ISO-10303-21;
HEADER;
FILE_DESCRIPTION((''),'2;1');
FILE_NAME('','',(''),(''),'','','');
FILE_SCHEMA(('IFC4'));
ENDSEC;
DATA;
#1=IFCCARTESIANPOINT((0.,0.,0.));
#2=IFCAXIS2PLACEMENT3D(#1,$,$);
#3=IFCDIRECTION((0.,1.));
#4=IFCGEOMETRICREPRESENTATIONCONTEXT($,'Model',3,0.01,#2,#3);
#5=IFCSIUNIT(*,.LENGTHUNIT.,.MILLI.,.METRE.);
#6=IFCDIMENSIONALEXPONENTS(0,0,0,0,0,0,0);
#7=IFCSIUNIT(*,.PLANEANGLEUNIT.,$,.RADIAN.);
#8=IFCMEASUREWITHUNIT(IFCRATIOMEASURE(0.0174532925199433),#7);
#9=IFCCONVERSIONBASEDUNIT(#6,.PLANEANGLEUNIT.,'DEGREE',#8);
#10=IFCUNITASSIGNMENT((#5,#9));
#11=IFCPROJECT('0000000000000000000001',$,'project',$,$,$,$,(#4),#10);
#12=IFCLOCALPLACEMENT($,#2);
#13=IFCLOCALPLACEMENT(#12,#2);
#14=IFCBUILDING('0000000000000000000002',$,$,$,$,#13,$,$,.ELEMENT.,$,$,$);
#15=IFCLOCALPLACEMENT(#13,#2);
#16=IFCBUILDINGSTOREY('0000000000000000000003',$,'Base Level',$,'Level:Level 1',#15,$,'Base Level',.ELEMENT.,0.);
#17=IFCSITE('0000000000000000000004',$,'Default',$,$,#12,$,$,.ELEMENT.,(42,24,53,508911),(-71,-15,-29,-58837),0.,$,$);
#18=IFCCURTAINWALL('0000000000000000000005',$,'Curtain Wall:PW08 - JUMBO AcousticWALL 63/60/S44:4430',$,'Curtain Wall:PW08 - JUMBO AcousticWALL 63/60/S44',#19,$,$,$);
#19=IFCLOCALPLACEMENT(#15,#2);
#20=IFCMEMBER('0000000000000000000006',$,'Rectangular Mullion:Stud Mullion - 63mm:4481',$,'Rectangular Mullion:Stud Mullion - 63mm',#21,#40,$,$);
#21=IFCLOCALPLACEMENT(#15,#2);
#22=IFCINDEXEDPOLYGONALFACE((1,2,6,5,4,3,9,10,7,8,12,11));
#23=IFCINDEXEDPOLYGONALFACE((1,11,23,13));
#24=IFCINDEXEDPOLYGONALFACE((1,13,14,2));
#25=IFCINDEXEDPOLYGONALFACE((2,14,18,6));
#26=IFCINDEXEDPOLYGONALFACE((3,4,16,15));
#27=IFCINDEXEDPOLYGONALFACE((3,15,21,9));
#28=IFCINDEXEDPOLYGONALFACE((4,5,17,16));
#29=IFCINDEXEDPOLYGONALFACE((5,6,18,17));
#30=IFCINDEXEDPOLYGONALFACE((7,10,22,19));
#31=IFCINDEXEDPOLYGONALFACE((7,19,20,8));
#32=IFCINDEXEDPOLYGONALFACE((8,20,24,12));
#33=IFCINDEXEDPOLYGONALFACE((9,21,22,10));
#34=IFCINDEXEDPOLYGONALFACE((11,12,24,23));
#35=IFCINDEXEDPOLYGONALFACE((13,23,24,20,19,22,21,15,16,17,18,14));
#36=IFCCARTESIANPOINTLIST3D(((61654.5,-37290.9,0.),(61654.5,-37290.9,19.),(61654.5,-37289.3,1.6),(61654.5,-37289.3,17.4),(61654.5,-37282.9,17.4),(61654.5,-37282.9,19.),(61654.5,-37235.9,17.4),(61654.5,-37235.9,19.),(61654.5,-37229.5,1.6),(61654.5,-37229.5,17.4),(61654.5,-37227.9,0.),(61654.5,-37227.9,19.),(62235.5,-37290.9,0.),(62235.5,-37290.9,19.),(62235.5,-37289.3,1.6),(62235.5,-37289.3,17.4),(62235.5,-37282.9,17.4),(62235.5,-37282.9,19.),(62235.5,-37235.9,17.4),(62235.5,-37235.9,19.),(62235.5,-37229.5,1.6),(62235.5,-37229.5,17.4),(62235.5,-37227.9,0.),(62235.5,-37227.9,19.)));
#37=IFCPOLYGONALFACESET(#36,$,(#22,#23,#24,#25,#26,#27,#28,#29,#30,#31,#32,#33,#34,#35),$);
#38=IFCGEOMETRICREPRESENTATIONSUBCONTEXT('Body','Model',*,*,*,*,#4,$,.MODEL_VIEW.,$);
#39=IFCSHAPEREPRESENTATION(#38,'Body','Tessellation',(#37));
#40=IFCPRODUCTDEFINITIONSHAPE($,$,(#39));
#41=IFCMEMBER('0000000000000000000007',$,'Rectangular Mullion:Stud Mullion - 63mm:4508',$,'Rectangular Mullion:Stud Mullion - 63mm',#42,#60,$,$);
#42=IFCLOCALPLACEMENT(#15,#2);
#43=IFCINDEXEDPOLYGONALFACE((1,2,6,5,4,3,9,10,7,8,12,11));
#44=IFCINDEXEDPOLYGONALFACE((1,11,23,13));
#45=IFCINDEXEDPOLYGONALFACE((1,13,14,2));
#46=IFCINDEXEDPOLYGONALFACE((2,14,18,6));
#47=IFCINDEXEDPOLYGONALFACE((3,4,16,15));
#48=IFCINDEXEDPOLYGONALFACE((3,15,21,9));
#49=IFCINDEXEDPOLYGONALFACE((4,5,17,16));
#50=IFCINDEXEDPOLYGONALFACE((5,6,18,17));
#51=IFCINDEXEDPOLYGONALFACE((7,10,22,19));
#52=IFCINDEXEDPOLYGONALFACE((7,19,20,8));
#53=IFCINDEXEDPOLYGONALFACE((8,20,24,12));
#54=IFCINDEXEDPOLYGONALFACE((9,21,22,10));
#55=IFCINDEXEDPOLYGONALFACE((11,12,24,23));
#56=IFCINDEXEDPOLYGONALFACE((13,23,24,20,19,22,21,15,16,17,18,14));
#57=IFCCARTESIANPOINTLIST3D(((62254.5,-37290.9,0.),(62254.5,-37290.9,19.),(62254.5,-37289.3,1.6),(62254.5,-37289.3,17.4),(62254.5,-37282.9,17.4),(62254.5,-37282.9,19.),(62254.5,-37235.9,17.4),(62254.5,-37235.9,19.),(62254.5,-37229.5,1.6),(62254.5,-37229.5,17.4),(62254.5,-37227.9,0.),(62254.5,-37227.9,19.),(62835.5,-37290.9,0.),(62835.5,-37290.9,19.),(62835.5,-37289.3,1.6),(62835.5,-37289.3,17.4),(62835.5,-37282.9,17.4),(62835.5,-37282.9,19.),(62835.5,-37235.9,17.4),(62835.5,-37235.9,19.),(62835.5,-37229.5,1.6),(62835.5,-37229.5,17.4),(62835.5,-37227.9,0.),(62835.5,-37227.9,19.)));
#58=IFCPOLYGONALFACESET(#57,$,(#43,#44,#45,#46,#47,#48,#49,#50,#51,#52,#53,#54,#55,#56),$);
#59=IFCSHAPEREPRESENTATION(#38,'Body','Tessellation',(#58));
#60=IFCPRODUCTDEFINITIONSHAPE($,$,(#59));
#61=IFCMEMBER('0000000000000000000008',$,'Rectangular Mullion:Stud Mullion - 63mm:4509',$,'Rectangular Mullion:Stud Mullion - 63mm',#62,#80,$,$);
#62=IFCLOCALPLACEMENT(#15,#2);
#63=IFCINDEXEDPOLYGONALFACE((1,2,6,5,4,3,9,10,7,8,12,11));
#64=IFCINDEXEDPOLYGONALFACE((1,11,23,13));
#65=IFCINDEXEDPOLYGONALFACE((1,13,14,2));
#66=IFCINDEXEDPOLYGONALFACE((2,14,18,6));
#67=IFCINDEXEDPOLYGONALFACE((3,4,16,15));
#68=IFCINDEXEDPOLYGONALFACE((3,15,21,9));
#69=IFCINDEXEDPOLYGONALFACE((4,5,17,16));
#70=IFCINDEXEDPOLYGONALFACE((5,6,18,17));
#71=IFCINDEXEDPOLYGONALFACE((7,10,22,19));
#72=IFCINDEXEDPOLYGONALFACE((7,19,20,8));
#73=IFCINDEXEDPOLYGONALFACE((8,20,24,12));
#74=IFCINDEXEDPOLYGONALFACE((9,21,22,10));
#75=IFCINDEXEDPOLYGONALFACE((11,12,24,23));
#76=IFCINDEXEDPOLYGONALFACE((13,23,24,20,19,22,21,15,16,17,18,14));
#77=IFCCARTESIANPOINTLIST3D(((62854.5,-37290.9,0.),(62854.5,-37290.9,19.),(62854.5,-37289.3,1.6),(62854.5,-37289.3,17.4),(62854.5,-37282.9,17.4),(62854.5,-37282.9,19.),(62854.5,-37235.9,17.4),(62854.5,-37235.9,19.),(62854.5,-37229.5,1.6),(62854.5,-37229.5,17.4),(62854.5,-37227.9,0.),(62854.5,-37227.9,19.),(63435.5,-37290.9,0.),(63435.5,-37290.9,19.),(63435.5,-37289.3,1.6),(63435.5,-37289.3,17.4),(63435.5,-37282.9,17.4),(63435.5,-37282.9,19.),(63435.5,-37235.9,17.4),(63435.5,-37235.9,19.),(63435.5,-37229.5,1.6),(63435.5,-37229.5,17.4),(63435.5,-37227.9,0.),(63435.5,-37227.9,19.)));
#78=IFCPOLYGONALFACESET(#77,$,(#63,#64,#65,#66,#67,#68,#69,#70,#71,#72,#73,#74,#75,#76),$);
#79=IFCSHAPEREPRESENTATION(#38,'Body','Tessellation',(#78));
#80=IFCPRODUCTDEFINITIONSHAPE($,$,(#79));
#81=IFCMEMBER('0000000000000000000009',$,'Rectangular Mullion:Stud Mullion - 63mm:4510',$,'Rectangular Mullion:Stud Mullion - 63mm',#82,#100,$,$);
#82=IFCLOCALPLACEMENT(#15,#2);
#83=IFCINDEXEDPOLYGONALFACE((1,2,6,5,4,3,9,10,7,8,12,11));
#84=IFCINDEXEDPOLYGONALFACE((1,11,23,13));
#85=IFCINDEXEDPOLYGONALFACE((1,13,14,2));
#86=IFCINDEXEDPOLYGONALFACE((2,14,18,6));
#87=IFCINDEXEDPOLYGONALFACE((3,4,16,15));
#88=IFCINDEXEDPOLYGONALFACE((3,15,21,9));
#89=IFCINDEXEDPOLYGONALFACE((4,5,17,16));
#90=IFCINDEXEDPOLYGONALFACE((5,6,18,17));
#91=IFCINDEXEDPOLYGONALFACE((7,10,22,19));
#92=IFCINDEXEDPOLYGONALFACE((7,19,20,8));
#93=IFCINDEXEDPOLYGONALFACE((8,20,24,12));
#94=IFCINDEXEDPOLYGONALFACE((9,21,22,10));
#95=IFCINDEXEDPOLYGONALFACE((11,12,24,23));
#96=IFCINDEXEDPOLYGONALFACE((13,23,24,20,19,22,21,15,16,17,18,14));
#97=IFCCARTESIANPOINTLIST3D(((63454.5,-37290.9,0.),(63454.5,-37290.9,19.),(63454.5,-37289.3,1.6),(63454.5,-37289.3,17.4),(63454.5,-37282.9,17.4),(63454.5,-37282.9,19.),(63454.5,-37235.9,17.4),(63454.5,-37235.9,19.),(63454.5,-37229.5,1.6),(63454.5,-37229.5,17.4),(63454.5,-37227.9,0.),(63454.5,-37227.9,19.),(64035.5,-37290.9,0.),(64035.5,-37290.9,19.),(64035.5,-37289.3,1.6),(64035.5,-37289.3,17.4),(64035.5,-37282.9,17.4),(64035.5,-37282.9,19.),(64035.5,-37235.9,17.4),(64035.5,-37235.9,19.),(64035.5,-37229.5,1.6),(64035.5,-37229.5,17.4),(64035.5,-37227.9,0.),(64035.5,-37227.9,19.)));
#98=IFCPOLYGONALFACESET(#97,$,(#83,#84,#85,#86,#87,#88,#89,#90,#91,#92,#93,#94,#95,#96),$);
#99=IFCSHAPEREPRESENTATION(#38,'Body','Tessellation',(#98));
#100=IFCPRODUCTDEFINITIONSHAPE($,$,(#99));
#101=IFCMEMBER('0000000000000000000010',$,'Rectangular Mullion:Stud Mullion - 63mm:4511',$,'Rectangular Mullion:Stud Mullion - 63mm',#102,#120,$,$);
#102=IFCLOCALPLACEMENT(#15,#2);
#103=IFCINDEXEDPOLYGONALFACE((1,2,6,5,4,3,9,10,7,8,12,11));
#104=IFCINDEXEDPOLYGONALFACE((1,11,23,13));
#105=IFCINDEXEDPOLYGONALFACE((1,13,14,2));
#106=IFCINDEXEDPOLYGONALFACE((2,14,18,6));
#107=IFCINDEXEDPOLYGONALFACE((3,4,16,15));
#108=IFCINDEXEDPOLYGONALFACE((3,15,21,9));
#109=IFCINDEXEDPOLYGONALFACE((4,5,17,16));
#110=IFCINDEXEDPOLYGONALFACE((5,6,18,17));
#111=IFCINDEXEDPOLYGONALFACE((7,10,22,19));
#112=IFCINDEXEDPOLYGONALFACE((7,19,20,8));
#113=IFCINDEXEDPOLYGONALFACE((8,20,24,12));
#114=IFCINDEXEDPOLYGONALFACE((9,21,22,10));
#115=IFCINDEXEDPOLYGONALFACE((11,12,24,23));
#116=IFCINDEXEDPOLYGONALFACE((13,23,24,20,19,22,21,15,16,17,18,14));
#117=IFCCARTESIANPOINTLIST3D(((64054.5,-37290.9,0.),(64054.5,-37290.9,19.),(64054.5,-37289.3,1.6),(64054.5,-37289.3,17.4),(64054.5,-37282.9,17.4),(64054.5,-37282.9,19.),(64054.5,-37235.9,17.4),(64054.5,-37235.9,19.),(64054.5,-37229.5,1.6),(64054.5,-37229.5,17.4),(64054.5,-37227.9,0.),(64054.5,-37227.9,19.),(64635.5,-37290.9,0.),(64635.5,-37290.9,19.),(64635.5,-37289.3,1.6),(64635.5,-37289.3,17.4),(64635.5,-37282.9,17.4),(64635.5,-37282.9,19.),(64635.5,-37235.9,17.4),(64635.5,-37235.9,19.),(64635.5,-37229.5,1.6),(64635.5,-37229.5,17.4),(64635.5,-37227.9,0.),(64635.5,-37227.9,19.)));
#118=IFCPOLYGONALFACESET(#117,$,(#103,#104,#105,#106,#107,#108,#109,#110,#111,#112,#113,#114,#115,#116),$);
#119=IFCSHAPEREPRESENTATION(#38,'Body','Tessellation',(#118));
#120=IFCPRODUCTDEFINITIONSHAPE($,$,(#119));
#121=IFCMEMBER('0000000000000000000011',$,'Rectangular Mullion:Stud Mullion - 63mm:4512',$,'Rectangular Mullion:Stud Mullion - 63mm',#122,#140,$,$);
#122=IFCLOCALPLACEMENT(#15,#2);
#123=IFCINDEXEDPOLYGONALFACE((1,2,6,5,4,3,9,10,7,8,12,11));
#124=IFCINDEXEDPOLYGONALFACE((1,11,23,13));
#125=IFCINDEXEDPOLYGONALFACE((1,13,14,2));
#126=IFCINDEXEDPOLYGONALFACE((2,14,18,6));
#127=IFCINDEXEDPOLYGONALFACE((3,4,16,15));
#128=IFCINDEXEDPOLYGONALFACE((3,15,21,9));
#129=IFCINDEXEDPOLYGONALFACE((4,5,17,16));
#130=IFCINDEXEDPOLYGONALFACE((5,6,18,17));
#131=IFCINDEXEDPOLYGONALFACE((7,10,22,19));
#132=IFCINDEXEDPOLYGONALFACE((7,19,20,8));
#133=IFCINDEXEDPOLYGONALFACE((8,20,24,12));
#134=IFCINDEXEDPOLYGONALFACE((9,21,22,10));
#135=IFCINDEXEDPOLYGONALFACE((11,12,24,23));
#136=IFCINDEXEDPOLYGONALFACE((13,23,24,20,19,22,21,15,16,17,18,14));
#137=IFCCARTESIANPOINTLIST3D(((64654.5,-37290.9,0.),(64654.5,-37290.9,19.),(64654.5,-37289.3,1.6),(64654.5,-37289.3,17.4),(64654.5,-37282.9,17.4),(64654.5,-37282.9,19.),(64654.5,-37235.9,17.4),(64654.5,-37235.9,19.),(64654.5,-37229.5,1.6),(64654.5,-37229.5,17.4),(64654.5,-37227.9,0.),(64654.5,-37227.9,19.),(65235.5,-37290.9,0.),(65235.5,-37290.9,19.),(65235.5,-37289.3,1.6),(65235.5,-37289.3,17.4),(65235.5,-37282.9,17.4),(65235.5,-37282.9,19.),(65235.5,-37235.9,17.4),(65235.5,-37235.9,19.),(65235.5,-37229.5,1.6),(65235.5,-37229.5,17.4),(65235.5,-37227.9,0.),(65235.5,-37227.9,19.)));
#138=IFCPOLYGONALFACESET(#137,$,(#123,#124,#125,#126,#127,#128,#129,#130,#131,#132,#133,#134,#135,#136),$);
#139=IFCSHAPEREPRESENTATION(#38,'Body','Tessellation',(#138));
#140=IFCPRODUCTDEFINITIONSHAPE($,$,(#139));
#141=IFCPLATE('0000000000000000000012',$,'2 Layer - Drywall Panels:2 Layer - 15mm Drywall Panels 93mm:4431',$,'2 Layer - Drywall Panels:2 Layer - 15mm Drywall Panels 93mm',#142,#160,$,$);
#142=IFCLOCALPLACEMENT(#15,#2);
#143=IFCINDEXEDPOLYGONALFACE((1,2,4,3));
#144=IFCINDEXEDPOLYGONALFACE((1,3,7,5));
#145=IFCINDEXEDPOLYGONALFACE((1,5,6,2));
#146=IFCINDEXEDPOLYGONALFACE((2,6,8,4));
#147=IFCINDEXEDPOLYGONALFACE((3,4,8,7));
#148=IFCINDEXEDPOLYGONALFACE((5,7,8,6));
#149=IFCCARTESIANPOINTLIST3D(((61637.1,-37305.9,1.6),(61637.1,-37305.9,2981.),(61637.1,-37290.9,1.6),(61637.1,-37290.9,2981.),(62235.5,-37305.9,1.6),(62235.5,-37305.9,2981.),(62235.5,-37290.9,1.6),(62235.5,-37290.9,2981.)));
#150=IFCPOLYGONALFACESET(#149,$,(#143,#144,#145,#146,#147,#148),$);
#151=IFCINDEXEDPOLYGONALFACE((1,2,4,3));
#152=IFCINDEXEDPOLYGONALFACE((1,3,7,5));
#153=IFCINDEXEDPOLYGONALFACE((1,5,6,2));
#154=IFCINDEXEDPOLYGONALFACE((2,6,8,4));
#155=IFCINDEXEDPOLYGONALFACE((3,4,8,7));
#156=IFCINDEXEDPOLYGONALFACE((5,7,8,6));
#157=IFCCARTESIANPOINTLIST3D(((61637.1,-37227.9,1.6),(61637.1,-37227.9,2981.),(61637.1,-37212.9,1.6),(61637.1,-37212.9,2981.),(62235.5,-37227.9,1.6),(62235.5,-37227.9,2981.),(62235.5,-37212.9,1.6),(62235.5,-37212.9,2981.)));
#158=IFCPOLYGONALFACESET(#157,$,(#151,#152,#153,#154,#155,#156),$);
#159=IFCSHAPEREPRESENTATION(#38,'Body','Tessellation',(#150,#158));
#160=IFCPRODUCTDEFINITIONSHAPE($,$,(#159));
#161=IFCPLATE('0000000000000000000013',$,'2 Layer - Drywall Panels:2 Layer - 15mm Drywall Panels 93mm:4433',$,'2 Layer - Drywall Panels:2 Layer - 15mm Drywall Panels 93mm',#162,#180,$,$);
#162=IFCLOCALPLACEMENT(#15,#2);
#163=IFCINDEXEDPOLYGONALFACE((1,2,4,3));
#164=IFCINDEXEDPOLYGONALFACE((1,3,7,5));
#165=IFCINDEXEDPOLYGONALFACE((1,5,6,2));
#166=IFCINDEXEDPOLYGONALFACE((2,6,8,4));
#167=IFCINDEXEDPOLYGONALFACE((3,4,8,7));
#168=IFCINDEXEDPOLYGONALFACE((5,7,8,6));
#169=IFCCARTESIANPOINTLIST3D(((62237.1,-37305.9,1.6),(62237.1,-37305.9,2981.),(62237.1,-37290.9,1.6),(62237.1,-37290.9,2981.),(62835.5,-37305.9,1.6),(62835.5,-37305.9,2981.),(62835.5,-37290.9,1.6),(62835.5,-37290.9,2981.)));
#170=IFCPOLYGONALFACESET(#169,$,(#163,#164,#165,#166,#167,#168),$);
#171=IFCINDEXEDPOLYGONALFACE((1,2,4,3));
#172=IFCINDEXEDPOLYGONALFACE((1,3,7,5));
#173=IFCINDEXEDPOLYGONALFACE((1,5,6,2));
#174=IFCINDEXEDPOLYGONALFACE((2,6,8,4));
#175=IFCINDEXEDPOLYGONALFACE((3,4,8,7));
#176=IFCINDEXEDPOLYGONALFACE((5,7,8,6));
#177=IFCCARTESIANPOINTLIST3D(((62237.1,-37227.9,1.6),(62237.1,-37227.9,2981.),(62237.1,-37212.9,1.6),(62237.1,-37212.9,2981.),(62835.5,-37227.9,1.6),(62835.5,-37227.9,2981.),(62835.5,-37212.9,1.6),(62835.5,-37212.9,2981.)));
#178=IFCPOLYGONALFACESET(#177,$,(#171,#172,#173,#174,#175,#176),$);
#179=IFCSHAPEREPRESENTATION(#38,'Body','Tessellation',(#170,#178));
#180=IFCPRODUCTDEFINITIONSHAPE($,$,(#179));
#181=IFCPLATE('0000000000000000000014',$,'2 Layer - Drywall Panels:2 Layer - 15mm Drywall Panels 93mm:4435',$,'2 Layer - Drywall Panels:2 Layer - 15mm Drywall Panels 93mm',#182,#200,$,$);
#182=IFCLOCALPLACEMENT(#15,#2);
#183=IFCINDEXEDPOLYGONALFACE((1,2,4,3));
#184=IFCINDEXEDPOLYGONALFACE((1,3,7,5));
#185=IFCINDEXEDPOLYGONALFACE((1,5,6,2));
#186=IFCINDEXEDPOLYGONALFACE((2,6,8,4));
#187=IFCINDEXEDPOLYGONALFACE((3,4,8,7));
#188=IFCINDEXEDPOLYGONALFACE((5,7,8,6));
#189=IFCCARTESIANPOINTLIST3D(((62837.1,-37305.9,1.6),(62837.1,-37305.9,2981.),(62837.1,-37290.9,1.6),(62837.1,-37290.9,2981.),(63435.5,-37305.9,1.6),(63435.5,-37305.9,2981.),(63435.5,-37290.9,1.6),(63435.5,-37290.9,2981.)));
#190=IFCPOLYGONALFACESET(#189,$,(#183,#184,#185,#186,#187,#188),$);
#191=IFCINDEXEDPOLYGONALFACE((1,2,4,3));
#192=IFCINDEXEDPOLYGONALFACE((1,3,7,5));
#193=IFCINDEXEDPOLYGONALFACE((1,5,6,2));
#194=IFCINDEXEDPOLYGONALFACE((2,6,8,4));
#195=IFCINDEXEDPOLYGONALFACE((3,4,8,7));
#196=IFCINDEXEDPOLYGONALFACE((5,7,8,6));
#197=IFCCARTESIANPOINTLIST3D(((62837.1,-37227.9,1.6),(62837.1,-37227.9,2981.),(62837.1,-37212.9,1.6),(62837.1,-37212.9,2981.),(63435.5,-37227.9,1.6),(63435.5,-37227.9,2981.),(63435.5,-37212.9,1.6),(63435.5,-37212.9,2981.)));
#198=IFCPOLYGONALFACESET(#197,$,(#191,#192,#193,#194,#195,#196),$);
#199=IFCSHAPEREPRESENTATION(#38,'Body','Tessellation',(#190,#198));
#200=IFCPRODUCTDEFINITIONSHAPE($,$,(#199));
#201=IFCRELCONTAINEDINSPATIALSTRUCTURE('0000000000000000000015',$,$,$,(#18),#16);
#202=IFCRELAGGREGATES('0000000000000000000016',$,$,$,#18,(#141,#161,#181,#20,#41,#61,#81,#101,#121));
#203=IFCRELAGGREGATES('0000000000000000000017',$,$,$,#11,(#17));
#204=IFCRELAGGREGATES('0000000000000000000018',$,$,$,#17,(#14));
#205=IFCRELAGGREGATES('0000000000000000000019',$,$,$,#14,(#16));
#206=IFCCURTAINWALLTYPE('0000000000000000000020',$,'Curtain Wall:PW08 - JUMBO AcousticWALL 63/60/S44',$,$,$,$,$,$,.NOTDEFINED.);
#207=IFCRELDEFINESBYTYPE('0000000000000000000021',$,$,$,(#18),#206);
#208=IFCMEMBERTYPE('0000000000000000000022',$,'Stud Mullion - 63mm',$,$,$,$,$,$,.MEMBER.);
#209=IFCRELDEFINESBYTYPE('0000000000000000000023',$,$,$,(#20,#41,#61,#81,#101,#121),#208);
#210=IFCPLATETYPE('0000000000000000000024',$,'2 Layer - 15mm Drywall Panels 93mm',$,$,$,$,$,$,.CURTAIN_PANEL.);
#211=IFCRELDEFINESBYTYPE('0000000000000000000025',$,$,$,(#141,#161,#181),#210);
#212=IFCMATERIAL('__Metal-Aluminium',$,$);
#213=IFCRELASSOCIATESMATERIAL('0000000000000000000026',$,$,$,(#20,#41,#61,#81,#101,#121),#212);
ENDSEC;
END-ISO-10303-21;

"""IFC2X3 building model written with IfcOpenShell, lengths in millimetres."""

from ifc_helpers import new_model, entity, si_unit, converted_unit, direction, frame, frame_2d, origin, place, context, subcontext, project, spatial, polyline, rectangle, outline, extrude, source, transform, mapped, material, type_object, type_shapes, element, aggregate, save


model = new_model("IFC2X3")

# Units and contexts
model_context = context("Model", 3, precision=0.01, world=origin(), true_north=direction((0.0, 1.0)))
body_context = subcontext(model_context, "Body", "Model", "MODEL_VIEW")
ifc_project = project(units=[si_unit("LENGTHUNIT", "METRE", prefix="MILLI"), converted_unit("PLANEANGLEUNIT", "DEGREE", entity("IfcRatioMeasure", 0.0174532925199433), si_unit("PLANEANGLEUNIT", "RADIAN"), dimensions=[0, 0, 0, 0, 0, 0, 0])], contexts=[model_context])

# Site, building, storey
site_placement = place(None, origin())
site = spatial("IfcSite", under=ifc_project, at=site_placement, Name="Default", CompositionType="ELEMENT", RefLatitude=(42, 24, 53, 508911), RefLongitude=(-71, -15, -29, -58837), RefElevation=0.0)
building_placement = place(site_placement, origin())
building = spatial("IfcBuilding", under=site, at=building_placement, CompositionType="ELEMENT")
storey_placement = place(building_placement, origin())
storey = spatial("IfcBuildingStorey", under=building, at=storey_placement, Name="Base Level", ObjectType="Level:Level 1", LongName="Base Level", CompositionType="ELEMENT", Elevation=0.0)

# Curtain wall, members, plates
curtain_wall_type = type_object("IfcCurtainWallType", Name="Curtain Wall:PW08 - JUMBO AcousticWALL 63/60/S44", PredefinedType="NOTDEFINED")
curtain_wall_placement = place(building_placement, origin())
curtain_wall = element("IfcCurtainWall", 1, at=curtain_wall_placement, inside=storey, type_object=curtain_wall_type, Name="Curtain Wall:PW08 - JUMBO AcousticWALL 63/60/S44:4430", ObjectType="Curtain Wall:PW08 - JUMBO AcousticWALL 63/60/S44")
ifc_material_1 = material(Name="__Metal-Aluminium")
member_type_1 = type_object("IfcMemberType", Name="Stud Mullion - 63mm", PredefinedType="MEMBER")
shared_shape_1 = source(origin(), body_context, "Body", "SweptSolid", [
    extrude(outline(polyline([(23.5, -6.6), (31.5, -6.6), (31.5, 12.4), (-31.5, 12.4), (-31.5, -6.6), (-23.5, -6.6), (-23.5, -5.0), (-29.9, -5.0), (-29.9, 10.8), (29.9, 10.8), (29.9, -5.0), (23.5, -5.0), (23.5, -6.6)])), frame((-12.4, 0.0, -581.0), z_axis=(0.0, 0.0, 1.0), x_axis=(0.0, -1.0, 0.0)), (0.0, 0.0, 1.0), 581.0),
])
type_shapes(member_type_1, [shared_shape_1])
member_1_placement = place(building_placement, frame((61654.5, -37259.4, 0.0), z_axis=(-1.0, 0.0, 0.0), x_axis=(0.0, 0.0, -1.0)))
member_1 = element("IfcMember", 2, at=member_1_placement, type_object=member_type_1, material=ifc_material_1, Name="Rectangular Mullion:Stud Mullion - 63mm:4481", ObjectType="Rectangular Mullion:Stud Mullion - 63mm", context=body_context, shape_type="MappedRepresentation", body=[
    mapped(shared_shape_1, transform((0.0, 0.0, 0.0), scale=1.0)),
])
member_2_placement = place(building_placement, frame((62254.5, -37259.4, 0.0), z_axis=(-1.0, 0.0, 0.0), x_axis=(0.0, 0.0, -1.0)))
member_2 = element("IfcMember", 3, at=member_2_placement, type_object=member_type_1, material=ifc_material_1, Name="Rectangular Mullion:Stud Mullion - 63mm:4508", ObjectType="Rectangular Mullion:Stud Mullion - 63mm", context=body_context, shape_type="MappedRepresentation", body=[
    mapped(shared_shape_1, transform((0.0, 0.0, 0.0), scale=1.0)),
])
member_3_placement = place(building_placement, frame((62854.5, -37259.4, 0.0), z_axis=(-1.0, 0.0, 0.0), x_axis=(0.0, 0.0, -1.0)))
member_3 = element("IfcMember", 4, at=member_3_placement, type_object=member_type_1, material=ifc_material_1, Name="Rectangular Mullion:Stud Mullion - 63mm:4509", ObjectType="Rectangular Mullion:Stud Mullion - 63mm", context=body_context, shape_type="MappedRepresentation", body=[
    mapped(shared_shape_1, transform((0.0, 0.0, 0.0), scale=1.0)),
])
member_4_placement = place(building_placement, frame((63454.5, -37259.4, 0.0), z_axis=(-1.0, 0.0, 0.0), x_axis=(0.0, 0.0, -1.0)))
member_4 = element("IfcMember", 5, at=member_4_placement, type_object=member_type_1, material=ifc_material_1, Name="Rectangular Mullion:Stud Mullion - 63mm:4510", ObjectType="Rectangular Mullion:Stud Mullion - 63mm", context=body_context, shape_type="MappedRepresentation", body=[
    mapped(shared_shape_1, transform((0.0, 0.0, 0.0), scale=1.0)),
])
member_5_placement = place(building_placement, frame((64054.5, -37259.4, 0.0), z_axis=(-1.0, 0.0, 0.0), x_axis=(0.0, 0.0, -1.0)))
member_5 = element("IfcMember", 6, at=member_5_placement, type_object=member_type_1, material=ifc_material_1, Name="Rectangular Mullion:Stud Mullion - 63mm:4511", ObjectType="Rectangular Mullion:Stud Mullion - 63mm", context=body_context, shape_type="MappedRepresentation", body=[
    mapped(shared_shape_1, transform((0.0, 0.0, 0.0), scale=1.0)),
])
member_6_placement = place(building_placement, frame((64654.5, -37259.4, 0.0), z_axis=(-1.0, 0.0, 0.0), x_axis=(0.0, 0.0, -1.0)))
member_6 = element("IfcMember", 7, at=member_6_placement, type_object=member_type_1, material=ifc_material_1, Name="Rectangular Mullion:Stud Mullion - 63mm:4512", ObjectType="Rectangular Mullion:Stud Mullion - 63mm", context=body_context, shape_type="MappedRepresentation", body=[
    mapped(shared_shape_1, transform((0.0, 0.0, 0.0), scale=1.0)),
])
plate_type = type_object("IfcPlateType", Name="2 Layer - 15mm Drywall Panels 93mm", PredefinedType="CURTAIN_PANEL")
shared_shape_2 = source(origin(), body_context, "Body", "SweptSolid", [
    extrude(rectangle(XDim=598.4, YDim=15.0, at=frame_2d((0.0, 0.0), x_axis=(1.0, 0.0))), frame((0.0, -39.0, 0.0), z_axis=(0.0, 0.0, 1.0), x_axis=(-1.0, 0.0, 0.0)), (0.0, 0.0, 1.0), 2979.4),
    extrude(rectangle(XDim=15.0, YDim=598.4, at=frame_2d((0.0, 0.0), x_axis=(1.0, 0.0))), frame((0.0, 39.0, 0.0), z_axis=(0.0, 0.0, 1.0), x_axis=(0.0, 1.0, 0.0)), (0.0, 0.0, 1.0), 2979.4),
])
type_shapes(plate_type, [shared_shape_2])
plate_1_placement = place(curtain_wall_placement, frame((61936.3, -37259.4, 1.6)))
plate_1 = element("IfcPlate", 8, at=plate_1_placement, type_object=plate_type, Name="2 Layer - Drywall Panels:2 Layer - 15mm Drywall Panels 93mm:4431", ObjectType="2 Layer - Drywall Panels:2 Layer - 15mm Drywall Panels 93mm", context=body_context, shape_type="MappedRepresentation", body=[
    mapped(shared_shape_2, transform((0.0, 0.0, 0.0), scale=1.0)),
])
plate_2_placement = place(curtain_wall_placement, frame((62536.3, -37259.4, 1.6)))
plate_2 = element("IfcPlate", 9, at=plate_2_placement, type_object=plate_type, Name="2 Layer - Drywall Panels:2 Layer - 15mm Drywall Panels 93mm:4433", ObjectType="2 Layer - Drywall Panels:2 Layer - 15mm Drywall Panels 93mm", context=body_context, shape_type="MappedRepresentation", body=[
    mapped(shared_shape_2, transform((0.0, 0.0, 0.0), scale=1.0)),
])
plate_3_placement = place(curtain_wall_placement, frame((63136.3, -37259.4, 1.6)))
plate_3 = element("IfcPlate", 10, at=plate_3_placement, type_object=plate_type, Name="2 Layer - Drywall Panels:2 Layer - 15mm Drywall Panels 93mm:4435", ObjectType="2 Layer - Drywall Panels:2 Layer - 15mm Drywall Panels 93mm", context=body_context, shape_type="MappedRepresentation", body=[
    mapped(shared_shape_2, transform((0.0, 0.0, 0.0), scale=1.0)),
])
aggregate(curtain_wall, [plate_1, plate_2, plate_3, member_1, member_2, member_3, member_4, member_5, member_6])

save(model, "model.ifc")
